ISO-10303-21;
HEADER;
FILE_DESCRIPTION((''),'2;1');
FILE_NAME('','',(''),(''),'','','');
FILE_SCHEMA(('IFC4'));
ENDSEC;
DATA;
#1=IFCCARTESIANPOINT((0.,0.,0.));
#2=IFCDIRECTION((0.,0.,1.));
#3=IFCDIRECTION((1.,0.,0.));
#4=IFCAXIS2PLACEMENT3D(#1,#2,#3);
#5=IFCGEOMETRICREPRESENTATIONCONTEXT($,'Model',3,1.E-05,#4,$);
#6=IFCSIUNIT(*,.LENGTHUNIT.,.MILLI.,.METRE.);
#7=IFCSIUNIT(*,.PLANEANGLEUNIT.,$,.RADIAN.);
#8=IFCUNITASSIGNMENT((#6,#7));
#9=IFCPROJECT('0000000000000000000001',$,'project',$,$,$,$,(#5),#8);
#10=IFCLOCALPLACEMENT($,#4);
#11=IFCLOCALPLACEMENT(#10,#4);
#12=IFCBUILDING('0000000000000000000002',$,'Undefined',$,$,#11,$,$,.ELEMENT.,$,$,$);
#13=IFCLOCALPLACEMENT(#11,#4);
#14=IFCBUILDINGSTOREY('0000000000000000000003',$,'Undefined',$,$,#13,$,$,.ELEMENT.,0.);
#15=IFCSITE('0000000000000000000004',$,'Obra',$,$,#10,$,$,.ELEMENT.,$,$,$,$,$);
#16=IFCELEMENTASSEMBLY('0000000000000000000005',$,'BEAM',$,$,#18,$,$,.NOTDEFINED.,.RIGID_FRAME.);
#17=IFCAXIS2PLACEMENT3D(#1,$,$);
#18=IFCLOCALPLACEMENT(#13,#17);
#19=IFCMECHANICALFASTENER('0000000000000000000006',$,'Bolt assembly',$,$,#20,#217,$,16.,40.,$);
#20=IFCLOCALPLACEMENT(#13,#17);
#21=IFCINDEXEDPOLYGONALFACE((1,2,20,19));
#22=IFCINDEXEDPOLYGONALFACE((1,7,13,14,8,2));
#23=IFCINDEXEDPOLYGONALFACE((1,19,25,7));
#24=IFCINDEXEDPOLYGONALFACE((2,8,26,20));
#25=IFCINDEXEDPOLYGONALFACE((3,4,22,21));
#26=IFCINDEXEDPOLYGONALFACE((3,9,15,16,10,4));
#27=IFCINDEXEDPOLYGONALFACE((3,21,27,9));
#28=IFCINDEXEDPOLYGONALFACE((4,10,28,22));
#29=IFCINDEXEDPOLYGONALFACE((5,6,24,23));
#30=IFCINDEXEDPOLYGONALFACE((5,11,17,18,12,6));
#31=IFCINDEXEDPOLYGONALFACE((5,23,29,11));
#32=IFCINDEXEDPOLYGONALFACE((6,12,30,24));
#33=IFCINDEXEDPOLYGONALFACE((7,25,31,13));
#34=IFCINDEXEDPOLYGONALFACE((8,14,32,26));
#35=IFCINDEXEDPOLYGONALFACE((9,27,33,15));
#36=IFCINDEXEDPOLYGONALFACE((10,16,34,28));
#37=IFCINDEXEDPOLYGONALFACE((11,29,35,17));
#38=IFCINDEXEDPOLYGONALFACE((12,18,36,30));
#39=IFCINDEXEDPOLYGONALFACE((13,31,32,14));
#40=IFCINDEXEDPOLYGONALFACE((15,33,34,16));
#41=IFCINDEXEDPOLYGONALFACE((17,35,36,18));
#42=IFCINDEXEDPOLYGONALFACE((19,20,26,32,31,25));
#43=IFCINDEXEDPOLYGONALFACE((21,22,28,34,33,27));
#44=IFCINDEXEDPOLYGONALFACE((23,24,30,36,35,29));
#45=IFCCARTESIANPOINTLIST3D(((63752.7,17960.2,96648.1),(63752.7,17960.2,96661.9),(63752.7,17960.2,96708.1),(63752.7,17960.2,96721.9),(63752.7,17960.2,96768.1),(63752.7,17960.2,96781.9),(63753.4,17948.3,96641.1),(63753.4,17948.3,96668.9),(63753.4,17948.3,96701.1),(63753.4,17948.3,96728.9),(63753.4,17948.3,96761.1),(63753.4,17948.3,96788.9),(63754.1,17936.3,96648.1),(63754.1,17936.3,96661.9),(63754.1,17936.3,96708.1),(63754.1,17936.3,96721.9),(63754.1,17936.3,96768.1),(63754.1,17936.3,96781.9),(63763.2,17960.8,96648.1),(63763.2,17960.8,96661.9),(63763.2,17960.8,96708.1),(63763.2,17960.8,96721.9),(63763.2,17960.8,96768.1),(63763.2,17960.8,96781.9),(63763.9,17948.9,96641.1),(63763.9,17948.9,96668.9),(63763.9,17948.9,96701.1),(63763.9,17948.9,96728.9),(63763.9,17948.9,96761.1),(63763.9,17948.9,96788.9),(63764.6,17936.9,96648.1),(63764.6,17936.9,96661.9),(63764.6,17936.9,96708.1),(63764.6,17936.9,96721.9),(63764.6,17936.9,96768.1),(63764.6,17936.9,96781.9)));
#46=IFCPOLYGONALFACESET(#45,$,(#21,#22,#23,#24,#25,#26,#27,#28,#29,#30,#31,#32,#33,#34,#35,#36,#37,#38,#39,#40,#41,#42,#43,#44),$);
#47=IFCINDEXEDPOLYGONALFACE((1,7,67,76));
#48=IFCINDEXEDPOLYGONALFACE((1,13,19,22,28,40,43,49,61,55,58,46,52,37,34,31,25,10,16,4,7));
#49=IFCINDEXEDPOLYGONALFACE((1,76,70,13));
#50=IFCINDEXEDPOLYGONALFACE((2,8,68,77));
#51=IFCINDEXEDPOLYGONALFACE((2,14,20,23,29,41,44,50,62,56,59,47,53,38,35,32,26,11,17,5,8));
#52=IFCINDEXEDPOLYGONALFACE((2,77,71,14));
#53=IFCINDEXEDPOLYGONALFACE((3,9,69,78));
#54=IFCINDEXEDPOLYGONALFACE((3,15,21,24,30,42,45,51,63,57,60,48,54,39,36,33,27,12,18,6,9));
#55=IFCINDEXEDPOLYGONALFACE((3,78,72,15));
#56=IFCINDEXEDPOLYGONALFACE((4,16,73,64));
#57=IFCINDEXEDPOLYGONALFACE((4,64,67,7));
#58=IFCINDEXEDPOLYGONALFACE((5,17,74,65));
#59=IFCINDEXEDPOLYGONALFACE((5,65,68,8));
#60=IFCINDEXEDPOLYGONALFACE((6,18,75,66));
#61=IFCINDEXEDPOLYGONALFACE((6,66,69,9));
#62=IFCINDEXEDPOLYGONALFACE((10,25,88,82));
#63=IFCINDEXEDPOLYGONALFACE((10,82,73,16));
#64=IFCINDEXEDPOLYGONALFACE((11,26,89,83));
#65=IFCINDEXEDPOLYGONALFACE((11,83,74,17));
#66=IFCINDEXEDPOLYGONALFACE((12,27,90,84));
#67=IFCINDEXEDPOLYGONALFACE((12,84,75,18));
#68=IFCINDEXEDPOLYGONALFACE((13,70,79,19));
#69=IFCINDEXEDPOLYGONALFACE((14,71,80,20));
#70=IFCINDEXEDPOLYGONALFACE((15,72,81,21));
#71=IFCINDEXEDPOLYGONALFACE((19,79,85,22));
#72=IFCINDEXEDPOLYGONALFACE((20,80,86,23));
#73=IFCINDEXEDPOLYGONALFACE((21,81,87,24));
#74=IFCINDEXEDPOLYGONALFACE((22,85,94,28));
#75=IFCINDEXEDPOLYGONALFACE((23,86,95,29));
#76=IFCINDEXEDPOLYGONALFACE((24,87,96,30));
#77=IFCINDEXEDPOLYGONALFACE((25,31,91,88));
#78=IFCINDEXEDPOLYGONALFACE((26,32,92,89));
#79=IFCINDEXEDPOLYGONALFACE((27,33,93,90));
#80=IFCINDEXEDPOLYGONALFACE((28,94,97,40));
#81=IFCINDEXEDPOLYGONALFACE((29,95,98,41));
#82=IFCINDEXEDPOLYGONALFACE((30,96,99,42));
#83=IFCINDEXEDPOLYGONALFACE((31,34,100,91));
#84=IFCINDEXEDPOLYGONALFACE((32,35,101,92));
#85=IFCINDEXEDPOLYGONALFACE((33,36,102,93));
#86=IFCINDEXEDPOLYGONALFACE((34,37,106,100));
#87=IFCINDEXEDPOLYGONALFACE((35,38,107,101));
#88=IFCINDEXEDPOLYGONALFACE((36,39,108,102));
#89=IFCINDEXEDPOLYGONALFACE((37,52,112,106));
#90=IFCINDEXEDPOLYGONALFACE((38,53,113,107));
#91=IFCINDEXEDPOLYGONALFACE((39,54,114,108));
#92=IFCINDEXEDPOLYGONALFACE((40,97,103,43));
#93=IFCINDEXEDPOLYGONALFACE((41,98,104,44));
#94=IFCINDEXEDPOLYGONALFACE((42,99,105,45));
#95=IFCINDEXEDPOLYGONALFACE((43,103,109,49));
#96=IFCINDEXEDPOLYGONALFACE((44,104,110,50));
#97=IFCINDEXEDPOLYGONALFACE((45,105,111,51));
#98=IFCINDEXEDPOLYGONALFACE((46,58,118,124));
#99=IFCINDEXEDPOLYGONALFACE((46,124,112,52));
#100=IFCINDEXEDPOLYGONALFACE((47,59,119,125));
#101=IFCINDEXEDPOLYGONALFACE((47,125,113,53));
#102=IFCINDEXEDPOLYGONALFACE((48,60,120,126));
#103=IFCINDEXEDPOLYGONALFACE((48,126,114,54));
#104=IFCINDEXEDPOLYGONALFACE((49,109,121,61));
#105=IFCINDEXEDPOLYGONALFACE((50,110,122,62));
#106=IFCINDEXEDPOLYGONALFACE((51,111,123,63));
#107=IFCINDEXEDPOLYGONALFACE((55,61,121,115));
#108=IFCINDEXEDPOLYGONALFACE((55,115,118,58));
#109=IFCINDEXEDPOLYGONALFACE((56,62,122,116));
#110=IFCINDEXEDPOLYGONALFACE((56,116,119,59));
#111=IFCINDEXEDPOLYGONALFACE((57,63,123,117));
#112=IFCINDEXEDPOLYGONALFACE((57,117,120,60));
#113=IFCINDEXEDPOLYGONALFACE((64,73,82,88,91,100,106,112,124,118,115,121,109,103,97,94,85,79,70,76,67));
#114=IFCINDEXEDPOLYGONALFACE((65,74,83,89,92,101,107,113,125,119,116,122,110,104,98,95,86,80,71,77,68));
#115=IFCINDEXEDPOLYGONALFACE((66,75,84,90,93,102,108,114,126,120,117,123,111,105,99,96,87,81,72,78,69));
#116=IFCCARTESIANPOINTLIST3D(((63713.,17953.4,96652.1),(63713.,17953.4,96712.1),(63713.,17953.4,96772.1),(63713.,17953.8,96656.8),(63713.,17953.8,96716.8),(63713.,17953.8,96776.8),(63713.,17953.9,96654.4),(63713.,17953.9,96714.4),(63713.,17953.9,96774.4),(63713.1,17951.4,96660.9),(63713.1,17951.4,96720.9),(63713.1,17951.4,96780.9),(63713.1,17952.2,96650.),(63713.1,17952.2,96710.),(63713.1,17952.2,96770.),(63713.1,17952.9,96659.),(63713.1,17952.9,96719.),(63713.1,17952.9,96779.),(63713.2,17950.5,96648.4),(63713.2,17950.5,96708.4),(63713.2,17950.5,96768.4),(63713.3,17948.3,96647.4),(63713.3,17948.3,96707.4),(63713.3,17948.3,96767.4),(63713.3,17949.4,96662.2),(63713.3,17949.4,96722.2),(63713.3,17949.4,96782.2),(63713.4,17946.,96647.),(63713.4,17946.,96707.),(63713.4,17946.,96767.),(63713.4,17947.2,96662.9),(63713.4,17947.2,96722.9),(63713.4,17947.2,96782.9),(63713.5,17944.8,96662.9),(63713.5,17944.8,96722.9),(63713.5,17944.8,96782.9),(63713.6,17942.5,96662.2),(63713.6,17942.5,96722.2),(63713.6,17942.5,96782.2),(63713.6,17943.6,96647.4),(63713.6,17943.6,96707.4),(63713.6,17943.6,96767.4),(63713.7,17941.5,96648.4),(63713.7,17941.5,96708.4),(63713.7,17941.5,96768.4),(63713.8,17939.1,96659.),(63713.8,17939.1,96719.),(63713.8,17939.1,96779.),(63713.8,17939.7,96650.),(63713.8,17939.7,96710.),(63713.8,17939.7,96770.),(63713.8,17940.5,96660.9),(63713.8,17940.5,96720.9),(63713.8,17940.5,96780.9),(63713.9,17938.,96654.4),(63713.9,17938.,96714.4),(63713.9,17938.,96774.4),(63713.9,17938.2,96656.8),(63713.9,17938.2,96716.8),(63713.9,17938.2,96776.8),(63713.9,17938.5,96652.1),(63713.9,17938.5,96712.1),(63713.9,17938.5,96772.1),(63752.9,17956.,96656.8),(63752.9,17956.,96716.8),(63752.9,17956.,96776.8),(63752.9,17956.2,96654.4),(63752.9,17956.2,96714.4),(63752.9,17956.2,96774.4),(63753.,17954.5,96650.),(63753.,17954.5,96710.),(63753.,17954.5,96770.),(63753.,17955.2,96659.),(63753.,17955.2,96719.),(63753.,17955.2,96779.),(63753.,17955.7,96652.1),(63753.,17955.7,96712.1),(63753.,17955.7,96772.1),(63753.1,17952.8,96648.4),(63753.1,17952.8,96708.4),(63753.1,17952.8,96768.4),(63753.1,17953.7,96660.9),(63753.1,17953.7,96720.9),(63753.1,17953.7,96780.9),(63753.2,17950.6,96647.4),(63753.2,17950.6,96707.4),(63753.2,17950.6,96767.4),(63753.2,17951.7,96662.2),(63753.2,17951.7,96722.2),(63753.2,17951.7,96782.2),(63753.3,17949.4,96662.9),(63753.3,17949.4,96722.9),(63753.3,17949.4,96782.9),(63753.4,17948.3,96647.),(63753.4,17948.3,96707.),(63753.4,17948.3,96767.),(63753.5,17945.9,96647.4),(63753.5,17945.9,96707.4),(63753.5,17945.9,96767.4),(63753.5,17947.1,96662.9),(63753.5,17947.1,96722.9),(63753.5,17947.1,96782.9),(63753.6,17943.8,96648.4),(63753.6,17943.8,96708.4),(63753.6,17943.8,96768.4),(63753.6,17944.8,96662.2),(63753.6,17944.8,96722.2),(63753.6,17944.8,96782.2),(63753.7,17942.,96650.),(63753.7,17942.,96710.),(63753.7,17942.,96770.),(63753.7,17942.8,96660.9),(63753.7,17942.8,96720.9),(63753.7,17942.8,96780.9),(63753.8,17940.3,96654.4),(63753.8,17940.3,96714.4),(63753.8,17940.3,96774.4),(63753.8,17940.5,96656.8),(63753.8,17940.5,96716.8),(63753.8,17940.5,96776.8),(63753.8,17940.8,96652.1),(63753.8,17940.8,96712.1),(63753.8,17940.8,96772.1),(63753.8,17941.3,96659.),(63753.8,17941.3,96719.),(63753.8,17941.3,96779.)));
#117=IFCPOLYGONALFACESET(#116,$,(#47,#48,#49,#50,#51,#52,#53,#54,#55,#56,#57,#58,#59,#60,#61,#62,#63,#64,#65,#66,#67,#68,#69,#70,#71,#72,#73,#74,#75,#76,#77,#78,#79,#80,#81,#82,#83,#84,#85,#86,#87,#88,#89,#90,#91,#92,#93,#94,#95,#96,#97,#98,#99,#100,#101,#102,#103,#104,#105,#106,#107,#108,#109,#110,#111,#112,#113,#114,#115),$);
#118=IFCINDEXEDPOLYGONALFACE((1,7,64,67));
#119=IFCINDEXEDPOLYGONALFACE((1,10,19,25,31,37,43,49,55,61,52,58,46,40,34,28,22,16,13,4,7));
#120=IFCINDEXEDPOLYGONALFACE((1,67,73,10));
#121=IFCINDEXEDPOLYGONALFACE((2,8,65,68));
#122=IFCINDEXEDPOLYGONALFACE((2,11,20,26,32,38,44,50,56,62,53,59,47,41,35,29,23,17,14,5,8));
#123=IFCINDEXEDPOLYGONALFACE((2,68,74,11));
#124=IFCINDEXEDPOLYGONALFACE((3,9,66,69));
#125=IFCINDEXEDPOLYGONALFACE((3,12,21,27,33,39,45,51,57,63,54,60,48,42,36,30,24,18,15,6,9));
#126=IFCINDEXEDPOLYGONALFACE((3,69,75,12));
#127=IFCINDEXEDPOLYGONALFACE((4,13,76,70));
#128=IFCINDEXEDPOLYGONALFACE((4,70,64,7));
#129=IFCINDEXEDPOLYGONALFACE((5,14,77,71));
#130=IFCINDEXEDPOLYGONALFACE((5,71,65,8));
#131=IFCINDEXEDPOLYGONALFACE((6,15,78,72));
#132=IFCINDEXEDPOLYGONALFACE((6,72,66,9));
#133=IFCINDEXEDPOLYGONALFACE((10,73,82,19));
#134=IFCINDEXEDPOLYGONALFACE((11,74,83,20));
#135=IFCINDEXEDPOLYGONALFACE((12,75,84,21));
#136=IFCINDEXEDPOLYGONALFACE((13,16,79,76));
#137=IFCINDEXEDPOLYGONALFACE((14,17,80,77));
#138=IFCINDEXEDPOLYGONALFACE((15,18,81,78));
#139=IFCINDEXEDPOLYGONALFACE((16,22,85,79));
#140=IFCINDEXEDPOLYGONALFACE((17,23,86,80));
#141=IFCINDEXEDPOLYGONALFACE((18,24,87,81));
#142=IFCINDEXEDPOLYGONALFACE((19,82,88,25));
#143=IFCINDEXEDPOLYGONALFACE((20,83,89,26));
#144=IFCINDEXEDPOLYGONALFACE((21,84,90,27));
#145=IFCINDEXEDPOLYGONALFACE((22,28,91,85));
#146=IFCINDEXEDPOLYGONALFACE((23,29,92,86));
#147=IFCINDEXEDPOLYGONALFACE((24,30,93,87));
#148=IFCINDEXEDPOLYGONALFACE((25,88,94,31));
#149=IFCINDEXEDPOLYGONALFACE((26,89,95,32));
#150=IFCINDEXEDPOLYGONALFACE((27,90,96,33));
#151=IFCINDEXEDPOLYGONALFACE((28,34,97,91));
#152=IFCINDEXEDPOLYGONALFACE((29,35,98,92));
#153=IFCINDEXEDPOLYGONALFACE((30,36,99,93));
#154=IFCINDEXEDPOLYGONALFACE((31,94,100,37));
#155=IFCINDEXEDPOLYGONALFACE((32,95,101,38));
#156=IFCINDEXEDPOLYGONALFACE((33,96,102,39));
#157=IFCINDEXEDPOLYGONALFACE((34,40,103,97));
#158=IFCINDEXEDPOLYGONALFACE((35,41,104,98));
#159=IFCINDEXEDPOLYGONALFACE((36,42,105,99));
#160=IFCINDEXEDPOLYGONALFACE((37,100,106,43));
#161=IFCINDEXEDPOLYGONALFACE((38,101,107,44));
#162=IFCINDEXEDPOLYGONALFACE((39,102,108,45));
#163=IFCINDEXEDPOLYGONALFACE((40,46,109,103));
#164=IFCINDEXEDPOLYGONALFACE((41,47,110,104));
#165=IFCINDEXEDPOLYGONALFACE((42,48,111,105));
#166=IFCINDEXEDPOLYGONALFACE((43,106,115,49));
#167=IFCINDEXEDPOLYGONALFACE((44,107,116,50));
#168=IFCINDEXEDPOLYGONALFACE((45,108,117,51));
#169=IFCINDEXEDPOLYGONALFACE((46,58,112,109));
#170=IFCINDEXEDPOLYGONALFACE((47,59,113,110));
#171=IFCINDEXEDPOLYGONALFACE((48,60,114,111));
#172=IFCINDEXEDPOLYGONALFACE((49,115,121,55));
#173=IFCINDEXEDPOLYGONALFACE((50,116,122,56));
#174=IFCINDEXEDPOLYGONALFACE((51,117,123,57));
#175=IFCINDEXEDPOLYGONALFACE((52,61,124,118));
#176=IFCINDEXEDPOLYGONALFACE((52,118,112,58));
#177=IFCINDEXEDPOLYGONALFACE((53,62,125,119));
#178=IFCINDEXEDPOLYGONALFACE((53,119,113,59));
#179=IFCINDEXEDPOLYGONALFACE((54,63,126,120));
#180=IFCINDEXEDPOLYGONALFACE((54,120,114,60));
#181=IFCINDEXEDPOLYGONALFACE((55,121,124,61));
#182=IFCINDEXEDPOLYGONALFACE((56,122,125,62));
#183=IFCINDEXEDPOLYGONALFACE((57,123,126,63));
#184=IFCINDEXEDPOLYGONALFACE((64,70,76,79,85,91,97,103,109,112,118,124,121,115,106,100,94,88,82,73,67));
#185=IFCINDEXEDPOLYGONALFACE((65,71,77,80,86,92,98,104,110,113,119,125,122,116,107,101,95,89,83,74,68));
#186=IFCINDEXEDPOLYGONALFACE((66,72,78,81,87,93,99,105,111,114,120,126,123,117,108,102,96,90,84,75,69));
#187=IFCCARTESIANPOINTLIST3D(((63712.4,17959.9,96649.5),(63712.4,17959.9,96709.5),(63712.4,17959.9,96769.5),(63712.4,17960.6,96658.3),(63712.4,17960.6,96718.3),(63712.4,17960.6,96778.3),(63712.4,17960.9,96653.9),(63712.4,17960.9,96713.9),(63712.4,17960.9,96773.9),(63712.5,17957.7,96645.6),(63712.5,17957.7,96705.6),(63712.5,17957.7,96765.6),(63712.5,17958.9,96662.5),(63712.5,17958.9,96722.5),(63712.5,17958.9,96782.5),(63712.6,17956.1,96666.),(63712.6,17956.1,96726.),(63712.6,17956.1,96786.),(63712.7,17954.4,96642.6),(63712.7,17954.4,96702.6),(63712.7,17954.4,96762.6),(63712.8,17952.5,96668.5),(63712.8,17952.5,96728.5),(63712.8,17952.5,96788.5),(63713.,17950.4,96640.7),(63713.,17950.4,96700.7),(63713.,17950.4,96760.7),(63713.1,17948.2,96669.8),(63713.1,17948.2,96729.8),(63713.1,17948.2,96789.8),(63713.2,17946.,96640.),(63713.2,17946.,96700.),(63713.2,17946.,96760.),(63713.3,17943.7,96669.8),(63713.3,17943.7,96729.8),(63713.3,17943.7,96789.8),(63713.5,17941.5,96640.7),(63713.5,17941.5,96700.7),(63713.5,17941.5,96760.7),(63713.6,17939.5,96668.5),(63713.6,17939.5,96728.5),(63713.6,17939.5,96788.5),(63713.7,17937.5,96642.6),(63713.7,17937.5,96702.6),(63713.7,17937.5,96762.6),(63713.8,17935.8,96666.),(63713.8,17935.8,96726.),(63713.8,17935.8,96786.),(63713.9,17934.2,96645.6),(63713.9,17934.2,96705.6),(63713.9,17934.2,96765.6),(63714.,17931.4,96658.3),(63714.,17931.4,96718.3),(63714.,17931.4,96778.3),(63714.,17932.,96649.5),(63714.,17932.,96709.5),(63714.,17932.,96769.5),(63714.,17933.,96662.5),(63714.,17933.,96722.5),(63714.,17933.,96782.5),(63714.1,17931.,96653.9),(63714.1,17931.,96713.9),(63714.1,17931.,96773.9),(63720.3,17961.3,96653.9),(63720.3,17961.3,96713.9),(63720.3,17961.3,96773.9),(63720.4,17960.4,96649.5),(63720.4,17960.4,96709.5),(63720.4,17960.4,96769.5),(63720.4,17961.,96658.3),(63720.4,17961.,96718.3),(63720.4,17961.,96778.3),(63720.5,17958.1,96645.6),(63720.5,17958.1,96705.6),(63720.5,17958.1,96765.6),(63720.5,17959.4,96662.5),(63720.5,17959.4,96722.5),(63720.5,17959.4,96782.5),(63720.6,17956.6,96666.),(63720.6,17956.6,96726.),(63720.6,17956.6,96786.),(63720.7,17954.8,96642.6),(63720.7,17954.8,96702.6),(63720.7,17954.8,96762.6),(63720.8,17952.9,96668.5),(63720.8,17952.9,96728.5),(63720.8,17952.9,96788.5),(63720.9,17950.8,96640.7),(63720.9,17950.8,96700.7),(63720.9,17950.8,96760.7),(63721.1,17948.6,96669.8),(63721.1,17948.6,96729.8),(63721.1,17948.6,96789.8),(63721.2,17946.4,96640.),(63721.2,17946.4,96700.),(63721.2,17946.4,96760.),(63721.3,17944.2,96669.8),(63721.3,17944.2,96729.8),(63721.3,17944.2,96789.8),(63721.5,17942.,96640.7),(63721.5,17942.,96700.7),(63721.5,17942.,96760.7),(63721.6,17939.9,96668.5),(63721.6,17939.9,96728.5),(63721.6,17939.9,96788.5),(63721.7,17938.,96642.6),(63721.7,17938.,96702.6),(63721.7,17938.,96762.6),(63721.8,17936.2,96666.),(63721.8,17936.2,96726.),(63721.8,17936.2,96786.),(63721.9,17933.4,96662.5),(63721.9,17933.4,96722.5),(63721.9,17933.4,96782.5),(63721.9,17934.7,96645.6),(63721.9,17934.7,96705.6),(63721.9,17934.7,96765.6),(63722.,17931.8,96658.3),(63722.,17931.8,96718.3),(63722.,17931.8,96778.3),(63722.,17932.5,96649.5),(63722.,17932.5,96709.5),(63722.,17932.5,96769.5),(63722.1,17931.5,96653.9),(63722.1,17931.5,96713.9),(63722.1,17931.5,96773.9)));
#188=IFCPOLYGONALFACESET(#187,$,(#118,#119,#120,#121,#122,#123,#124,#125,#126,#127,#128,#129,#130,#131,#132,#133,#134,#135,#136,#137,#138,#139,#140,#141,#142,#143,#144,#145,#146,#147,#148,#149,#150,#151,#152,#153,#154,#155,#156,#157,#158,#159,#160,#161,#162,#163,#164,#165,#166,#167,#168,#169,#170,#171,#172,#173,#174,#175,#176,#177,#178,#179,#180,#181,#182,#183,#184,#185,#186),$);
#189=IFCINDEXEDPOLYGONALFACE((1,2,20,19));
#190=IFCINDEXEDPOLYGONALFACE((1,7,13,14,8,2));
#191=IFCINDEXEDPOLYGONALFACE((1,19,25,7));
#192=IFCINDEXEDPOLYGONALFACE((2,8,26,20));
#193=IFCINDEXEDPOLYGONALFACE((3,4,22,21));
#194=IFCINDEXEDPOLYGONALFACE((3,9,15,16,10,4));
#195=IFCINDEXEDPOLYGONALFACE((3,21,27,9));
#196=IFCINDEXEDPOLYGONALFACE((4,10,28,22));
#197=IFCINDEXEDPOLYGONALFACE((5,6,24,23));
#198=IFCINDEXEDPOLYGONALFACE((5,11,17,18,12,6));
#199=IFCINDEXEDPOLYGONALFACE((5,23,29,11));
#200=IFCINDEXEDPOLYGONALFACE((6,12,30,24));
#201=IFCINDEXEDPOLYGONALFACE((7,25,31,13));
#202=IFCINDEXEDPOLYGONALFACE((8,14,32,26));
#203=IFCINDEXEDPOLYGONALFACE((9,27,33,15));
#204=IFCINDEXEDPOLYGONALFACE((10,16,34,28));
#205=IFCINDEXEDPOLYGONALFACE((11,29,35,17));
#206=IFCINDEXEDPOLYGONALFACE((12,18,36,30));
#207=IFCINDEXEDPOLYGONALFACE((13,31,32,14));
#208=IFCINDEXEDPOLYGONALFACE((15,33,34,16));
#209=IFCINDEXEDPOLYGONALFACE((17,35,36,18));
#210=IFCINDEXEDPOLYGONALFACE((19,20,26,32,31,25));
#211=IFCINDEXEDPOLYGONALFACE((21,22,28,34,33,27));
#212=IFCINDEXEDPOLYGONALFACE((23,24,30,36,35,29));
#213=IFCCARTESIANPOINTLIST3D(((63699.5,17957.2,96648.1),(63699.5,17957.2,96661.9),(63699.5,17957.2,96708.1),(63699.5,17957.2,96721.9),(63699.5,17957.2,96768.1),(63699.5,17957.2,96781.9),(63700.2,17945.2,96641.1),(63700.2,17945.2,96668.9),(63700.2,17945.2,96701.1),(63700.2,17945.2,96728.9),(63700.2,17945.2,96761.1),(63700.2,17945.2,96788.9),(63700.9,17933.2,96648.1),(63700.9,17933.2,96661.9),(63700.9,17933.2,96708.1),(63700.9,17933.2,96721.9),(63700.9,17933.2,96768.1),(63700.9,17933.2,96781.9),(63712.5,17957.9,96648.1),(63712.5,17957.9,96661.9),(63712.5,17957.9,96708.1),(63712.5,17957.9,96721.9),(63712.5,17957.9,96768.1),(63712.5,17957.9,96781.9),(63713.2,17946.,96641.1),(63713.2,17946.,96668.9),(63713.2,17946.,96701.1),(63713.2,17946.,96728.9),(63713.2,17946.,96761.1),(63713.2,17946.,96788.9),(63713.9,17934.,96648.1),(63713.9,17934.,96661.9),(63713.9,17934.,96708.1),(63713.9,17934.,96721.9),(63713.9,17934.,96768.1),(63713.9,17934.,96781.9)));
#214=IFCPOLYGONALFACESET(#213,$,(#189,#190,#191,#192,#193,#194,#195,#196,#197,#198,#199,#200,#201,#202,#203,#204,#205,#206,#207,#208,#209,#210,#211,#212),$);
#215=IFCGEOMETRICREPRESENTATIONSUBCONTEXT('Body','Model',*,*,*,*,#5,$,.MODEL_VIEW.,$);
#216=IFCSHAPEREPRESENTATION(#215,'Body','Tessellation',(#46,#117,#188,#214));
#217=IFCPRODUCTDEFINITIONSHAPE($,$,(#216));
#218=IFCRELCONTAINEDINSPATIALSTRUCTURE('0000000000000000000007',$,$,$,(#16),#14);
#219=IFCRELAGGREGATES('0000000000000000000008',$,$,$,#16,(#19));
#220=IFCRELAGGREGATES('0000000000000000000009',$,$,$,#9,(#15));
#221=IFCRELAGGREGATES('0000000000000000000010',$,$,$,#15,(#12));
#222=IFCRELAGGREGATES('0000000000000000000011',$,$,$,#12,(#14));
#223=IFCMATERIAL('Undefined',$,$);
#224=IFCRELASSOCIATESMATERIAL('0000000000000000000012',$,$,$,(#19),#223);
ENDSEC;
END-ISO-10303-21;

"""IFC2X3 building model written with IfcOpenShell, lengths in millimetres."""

from ifc_helpers import new_model, si_unit, frame, origin_with_axes, origin_2d_with_axis, place, context, subcontext, project, spatial, polyline, circle, outline, extrude, source, transform, mapped, material, element, aggregate, save


model = new_model("IFC2X3")

# Units and contexts
model_context = context("Model", 3, precision=1e-05, world=origin_with_axes())
body_context = subcontext(model_context, "Body", "Model", "MODEL_VIEW")
ifc_project = project(units=[si_unit("LENGTHUNIT", "METRE", prefix="MILLI"), si_unit("PLANEANGLEUNIT", "RADIAN")], contexts=[model_context])

# Site, building, storey
site_placement = place(None, origin_with_axes())
site = spatial("IfcSite", under=ifc_project, at=site_placement, Name="Obra", CompositionType="ELEMENT")
building_placement = place(site_placement, origin_with_axes())
building = spatial("IfcBuilding", under=site, at=building_placement, Name="Undefined", CompositionType="ELEMENT")
storey_placement = place(building_placement, origin_with_axes())
storey = spatial("IfcBuildingStorey", under=building, at=storey_placement, Name="Undefined", CompositionType="ELEMENT", Elevation=0.0)

# Shared definitions
ifc_material_1 = material(Name="Undefined")

# Element assembly
assembly_1_placement = place(storey_placement, origin_with_axes())
assembly_1 = element("IfcElementAssembly", 1, at=assembly_1_placement, inside=storey, Name="BEAM", AssemblyPlace="NOTDEFINED", PredefinedType="RIGID_FRAME")

# Mechanical fastener
shared_shape_1 = source(origin_with_axes(), body_context, "Body", "SweptSolid", [
    extrude(outline(polyline([(13.9, 0.0), (6.9, 12.0), (-6.9, 12.0), (-13.9, 0.0), (-6.9, -12.0), (6.9, -12.0), (13.9, 0.0)])), frame((0.0, -45.9, 0.0), z_axis=(0.0, 1.0, 0.0), x_axis=(1.0, 0.0, 0.0)), (0.0, 0.0, 1.0), 10.6),
    extrude(circle(Radius=8.0, at=origin_2d_with_axis()), frame((0.0, -35.3, 0.0), z_axis=(0.0, 1.0, 0.0), x_axis=(1.0, 0.0, 0.0)), (0.0, 0.0, 1.0), 40.0),
    extrude(circle(Radius=15.0, at=origin_2d_with_axis()), frame((0.0, -3.1, 0.0), z_axis=(0.0, 1.0, 0.0), x_axis=(1.0, 0.0, 0.0)), (0.0, 0.0, 1.0), 8.0),
    extrude(outline(polyline([(13.9, 0.0), (6.9, 12.0), (-6.9, 12.0), (-13.9, 0.0), (-6.9, -12.0), (6.9, -12.0), (13.9, 0.0)])), frame((0.0, 4.9, 0.0), z_axis=(0.0, 1.0, 0.0), x_axis=(1.0, 0.0, 0.0)), (0.0, 0.0, 1.0), 13.0),
])
mechanical_fastener_1_placement = place(assembly_1_placement, frame((63721.0, 17896.3, 96835.0), z_axis=(-0.057107, 0.998368, 0.0), x_axis=(0.0, 0.0, -1.0)))
mechanical_fastener_1 = element("IfcMechanicalFastener", 2, at=mechanical_fastener_1_placement, material=ifc_material_1, Name="Bolt assembly", NominalDiameter=16.0, NominalLength=40.0, context=body_context, shape_type="MappedRepresentation", body=[
    mapped(shared_shape_1, transform((60.0, 0.0, 50.0))),
    mapped(shared_shape_1, transform((120.0, 0.0, 50.0))),
    mapped(shared_shape_1, transform((180.0, 0.0, 50.0))),
])
aggregate(assembly_1, [mechanical_fastener_1])

save(model, "model.ifc")
